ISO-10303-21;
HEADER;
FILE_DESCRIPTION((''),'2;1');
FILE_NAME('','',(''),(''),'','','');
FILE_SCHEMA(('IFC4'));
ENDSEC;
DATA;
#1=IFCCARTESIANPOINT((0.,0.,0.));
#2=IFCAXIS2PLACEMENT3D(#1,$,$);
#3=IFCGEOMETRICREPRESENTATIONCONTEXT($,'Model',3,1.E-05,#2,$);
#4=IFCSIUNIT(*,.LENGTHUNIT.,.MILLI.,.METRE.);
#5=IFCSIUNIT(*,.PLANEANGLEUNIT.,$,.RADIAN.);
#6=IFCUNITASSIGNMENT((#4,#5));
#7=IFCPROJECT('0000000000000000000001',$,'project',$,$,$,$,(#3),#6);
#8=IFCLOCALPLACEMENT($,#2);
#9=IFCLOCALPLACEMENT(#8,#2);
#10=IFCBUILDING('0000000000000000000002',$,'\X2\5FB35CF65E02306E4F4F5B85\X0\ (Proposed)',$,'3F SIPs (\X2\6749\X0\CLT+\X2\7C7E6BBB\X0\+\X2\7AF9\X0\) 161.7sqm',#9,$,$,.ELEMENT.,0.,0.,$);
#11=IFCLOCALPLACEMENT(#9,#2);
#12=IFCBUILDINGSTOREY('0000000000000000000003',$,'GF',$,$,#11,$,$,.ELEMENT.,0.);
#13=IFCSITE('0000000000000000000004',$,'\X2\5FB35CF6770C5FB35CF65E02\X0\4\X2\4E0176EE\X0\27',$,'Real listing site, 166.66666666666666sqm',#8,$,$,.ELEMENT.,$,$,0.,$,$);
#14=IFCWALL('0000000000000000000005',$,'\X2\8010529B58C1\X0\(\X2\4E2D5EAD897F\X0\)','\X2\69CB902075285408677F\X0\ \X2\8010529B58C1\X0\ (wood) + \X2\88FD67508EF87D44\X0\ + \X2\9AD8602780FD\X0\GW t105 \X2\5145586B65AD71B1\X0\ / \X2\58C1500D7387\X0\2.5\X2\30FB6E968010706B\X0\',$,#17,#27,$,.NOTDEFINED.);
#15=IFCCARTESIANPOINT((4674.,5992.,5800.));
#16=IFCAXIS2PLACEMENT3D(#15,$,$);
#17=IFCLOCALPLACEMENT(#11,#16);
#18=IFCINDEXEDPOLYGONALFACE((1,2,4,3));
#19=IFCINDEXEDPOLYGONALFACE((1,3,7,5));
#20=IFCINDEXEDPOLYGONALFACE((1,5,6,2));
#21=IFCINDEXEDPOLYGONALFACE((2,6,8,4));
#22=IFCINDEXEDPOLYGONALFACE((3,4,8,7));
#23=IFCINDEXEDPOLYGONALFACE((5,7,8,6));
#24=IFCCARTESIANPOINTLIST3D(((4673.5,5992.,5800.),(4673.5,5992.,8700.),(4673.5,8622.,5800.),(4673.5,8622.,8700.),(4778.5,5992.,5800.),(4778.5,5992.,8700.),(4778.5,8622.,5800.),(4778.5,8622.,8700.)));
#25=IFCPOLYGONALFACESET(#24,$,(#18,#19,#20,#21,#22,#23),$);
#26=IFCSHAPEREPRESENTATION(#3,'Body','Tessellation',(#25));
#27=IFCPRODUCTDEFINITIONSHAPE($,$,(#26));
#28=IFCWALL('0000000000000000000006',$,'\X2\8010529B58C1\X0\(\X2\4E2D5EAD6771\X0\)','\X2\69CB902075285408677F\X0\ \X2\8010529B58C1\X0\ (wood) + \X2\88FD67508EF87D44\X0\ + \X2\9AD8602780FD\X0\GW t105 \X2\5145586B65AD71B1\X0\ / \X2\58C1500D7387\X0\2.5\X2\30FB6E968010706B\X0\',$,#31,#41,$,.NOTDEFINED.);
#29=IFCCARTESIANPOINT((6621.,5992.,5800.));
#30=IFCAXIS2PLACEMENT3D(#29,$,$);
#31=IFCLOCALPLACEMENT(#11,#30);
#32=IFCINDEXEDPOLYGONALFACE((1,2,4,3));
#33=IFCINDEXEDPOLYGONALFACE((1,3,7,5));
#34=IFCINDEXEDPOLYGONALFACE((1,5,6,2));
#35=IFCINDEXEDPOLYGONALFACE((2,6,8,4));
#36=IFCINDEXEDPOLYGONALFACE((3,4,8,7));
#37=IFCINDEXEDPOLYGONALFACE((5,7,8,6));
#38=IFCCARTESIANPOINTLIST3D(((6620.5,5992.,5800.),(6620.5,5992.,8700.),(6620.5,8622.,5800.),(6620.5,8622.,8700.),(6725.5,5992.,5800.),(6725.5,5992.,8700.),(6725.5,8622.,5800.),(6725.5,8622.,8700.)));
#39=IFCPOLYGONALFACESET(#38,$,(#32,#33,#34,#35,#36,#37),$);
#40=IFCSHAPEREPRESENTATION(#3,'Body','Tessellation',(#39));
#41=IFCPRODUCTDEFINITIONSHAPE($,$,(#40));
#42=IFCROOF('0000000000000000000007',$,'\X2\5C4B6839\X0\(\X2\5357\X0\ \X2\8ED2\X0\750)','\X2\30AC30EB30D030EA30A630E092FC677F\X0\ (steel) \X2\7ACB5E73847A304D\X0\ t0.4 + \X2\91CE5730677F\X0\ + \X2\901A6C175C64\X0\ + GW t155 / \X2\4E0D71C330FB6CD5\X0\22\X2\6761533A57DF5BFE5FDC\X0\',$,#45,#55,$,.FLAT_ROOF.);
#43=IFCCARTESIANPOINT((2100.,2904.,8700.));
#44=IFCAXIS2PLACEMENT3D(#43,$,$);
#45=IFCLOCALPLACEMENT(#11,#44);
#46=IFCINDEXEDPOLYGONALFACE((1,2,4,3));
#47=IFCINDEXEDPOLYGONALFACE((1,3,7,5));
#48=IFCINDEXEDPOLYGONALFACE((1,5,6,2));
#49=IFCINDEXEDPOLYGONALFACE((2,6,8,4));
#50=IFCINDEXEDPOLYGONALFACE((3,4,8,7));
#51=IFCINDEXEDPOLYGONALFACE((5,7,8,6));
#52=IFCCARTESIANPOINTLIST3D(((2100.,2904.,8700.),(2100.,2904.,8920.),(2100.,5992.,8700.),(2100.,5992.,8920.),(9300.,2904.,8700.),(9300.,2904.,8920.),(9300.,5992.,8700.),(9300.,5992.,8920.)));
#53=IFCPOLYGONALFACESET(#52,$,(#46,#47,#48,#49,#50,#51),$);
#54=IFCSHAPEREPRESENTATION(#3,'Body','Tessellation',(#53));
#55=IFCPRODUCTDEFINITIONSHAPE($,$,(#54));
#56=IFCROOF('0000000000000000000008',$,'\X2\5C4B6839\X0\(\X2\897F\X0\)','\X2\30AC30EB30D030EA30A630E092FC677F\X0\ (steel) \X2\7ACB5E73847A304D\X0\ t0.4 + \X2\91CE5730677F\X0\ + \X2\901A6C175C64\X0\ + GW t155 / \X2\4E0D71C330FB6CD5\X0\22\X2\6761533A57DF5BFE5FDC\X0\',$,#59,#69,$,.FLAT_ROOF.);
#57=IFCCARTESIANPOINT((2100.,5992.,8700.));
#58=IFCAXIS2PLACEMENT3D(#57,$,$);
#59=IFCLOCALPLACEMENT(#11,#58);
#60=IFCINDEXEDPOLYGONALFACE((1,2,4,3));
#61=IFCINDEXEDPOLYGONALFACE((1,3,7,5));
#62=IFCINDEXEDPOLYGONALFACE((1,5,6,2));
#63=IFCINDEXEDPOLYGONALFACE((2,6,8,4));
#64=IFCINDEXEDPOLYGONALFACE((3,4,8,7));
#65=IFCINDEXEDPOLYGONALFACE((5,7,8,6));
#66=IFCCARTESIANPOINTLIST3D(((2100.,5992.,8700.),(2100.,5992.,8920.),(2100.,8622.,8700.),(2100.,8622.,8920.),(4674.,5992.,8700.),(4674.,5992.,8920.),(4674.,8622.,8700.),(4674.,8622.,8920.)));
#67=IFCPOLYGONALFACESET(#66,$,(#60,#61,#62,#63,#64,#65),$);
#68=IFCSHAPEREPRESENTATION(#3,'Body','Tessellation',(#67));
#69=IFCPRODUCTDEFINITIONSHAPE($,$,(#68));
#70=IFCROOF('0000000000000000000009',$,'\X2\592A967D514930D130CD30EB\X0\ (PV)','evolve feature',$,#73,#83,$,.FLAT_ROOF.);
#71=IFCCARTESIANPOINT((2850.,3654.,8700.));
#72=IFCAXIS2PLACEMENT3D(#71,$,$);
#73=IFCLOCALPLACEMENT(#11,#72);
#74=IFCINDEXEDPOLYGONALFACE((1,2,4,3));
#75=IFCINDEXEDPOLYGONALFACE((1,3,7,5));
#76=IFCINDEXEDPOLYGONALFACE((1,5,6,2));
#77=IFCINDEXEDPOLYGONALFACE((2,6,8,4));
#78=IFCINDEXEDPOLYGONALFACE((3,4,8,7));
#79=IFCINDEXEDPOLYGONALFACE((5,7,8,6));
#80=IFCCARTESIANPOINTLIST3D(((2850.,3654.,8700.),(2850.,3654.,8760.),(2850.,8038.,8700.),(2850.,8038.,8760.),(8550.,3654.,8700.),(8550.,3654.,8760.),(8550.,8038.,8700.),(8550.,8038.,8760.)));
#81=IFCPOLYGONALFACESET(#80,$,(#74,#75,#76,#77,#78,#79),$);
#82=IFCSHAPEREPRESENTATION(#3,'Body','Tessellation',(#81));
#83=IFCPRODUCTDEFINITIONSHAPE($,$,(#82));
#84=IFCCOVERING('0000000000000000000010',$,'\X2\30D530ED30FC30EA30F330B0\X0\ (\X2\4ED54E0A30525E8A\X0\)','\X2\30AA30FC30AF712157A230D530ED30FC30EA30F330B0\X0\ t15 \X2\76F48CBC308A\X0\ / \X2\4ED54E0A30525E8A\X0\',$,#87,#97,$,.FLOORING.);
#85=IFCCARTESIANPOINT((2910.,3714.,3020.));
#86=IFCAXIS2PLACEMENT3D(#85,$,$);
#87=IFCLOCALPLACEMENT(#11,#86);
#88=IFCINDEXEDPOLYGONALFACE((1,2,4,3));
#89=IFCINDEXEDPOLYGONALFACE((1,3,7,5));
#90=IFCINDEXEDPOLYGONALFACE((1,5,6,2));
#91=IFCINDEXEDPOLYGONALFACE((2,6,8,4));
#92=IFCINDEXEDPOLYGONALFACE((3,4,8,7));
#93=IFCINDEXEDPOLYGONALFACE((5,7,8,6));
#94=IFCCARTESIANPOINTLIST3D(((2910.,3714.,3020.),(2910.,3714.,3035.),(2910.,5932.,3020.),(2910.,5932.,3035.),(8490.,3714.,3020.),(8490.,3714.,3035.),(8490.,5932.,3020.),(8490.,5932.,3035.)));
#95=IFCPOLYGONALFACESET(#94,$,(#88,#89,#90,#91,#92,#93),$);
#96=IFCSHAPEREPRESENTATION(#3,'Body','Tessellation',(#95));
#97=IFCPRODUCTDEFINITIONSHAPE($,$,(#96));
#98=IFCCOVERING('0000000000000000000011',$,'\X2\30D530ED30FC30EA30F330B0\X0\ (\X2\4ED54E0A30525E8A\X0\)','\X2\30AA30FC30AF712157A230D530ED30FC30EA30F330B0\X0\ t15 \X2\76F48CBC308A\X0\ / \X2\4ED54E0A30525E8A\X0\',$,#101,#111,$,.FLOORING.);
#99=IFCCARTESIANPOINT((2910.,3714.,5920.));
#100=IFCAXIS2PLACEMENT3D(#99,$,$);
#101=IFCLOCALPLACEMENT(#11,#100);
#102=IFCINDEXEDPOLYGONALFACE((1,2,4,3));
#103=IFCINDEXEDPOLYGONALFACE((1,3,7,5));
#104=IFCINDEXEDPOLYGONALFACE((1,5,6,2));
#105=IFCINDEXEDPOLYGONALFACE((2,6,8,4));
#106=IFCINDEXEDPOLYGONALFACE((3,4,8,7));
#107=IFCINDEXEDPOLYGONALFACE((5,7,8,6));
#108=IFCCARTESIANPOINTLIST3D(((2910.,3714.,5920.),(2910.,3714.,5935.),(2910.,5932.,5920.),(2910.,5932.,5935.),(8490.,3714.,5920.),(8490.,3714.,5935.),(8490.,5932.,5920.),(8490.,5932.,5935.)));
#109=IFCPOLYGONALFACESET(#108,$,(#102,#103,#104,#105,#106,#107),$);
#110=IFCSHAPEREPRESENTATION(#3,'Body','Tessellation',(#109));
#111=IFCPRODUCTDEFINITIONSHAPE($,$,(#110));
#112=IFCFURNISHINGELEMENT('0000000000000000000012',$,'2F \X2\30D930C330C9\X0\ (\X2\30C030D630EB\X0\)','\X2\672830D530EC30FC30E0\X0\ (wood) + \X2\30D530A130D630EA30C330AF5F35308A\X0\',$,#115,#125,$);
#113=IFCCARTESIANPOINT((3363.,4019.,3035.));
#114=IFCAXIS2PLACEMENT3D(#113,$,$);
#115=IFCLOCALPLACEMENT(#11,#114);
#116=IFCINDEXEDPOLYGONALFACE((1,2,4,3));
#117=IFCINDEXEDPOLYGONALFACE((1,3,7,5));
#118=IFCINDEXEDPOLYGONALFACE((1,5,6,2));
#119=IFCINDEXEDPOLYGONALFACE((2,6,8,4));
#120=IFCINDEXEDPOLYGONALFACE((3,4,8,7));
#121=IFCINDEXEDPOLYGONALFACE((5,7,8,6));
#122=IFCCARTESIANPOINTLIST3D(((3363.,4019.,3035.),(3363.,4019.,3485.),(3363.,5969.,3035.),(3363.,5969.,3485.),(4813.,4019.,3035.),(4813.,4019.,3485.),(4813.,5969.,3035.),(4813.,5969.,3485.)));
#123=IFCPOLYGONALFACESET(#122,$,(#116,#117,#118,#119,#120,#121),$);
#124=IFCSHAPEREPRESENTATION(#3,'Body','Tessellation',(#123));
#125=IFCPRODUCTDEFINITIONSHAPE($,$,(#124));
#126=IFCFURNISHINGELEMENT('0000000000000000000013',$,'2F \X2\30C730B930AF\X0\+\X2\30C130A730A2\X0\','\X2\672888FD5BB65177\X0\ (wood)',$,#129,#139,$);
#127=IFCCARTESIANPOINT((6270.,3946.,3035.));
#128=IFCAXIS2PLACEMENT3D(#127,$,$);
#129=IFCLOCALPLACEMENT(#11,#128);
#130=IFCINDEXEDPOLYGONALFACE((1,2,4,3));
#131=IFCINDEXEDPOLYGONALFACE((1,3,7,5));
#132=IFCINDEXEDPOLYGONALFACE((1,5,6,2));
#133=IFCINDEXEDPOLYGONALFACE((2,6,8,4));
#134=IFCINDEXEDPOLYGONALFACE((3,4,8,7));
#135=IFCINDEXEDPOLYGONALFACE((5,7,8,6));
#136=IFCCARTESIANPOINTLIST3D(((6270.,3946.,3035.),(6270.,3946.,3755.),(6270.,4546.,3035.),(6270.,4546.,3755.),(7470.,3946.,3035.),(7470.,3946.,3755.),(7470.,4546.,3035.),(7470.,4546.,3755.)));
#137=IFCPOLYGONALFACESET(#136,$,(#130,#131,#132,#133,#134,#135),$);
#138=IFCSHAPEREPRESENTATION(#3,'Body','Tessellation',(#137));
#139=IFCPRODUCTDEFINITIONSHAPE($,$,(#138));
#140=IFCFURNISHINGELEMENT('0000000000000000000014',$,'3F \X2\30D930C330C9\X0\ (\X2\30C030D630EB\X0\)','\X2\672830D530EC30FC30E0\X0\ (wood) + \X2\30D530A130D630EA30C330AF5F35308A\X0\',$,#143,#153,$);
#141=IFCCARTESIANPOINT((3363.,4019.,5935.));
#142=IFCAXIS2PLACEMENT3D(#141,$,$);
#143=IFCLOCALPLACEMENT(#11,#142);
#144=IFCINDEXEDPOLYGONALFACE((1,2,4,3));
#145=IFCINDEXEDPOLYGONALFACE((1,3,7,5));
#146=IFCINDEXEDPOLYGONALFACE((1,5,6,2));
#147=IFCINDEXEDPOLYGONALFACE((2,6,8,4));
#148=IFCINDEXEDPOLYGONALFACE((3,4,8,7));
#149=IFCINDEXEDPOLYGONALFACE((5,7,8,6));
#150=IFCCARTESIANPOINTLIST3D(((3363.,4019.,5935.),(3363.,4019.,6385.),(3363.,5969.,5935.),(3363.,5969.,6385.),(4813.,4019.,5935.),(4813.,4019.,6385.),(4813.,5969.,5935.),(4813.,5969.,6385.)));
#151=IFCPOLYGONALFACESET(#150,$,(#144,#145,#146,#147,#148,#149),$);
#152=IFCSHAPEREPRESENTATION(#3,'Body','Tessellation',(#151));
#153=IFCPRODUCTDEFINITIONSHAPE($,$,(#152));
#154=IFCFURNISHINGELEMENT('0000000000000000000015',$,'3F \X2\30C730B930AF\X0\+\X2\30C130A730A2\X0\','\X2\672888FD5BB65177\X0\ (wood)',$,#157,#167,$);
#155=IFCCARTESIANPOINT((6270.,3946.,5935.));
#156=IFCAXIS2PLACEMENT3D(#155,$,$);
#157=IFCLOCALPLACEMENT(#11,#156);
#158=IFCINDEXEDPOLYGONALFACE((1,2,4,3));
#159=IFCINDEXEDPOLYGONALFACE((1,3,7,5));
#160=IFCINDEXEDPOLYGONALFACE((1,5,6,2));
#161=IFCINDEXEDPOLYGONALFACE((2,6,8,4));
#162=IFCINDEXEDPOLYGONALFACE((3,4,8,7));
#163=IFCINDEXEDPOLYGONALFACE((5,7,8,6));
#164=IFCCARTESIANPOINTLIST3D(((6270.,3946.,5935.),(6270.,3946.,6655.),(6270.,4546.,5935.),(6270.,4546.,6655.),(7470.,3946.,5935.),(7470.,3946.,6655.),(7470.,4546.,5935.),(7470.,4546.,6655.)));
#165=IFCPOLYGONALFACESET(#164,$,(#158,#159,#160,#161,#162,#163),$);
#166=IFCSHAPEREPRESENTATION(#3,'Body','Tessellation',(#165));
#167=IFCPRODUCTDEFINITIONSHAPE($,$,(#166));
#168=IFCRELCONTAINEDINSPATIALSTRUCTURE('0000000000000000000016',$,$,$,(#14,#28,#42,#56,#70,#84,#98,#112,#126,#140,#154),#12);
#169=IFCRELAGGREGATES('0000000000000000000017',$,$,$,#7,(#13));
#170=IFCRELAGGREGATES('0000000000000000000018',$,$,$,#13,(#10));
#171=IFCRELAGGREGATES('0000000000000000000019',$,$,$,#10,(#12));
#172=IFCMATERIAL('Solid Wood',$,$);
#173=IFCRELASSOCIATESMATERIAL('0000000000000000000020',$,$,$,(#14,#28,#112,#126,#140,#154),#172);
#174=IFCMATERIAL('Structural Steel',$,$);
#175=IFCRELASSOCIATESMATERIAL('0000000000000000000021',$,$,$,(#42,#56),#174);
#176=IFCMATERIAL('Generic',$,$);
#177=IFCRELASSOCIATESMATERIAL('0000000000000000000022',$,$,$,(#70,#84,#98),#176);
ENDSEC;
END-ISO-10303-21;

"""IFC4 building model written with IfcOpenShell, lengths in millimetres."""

from ifc_helpers import new_model, si_unit, frame, frame_2d, origin, place, context, project, spatial, rectangle, extrude, material, element, save


model = new_model("IFC4")

# Units and contexts
model_context = context("Model", 3, precision=1e-05, world=origin())
ifc_project = project(units=[si_unit("LENGTHUNIT", "METRE", prefix="MILLI"), si_unit("PLANEANGLEUNIT", "RADIAN")], contexts=[model_context])

# Site, building, storey
site_placement = place(None, origin())
site = spatial("IfcSite", under=ifc_project, at=site_placement, Name="徳島県徳島市4丁目27", ObjectType="Real listing site, 166.66666666666666sqm", CompositionType="ELEMENT", RefElevation=0.0)
building_placement = place(site_placement, origin())
building = spatial("IfcBuilding", under=site, at=building_placement, Name="徳島市の住宅 (Proposed)", ObjectType="3F SIPs (杉CLT+籾殻+竹) 161.7sqm", CompositionType="ELEMENT", ElevationOfRefHeight=0.0, ElevationOfTerrain=0.0)
storey_placement = place(building_placement, origin())
storey = spatial("IfcBuildingStorey", under=building, at=storey_placement, Name="GF", CompositionType="ELEMENT", Elevation=0.0)

# Shared definitions
ifc_material_1 = material(Name="Solid Wood")

# Walls
wall_1_placement = place(storey_placement, frame((4674.0, 5992.0, 5800.0)))
element("IfcWall", 1, at=wall_1_placement, inside=storey, material=ifc_material_1, Name="耐力壁(中庭西)", Description="構造用合板 耐力壁 (wood) + 製材軸組 + 高性能GW t105 充填断熱 / 壁倍率2.5・準耐火", PredefinedType="NOTDEFINED", context=model_context, shape_type="SweptSolid", body=[
    extrude(rectangle(XDim=105.0, YDim=2630.0, at=frame_2d((52.0, 1315.0))), frame((4674.0, 5992.0, 5800.0)), (0.0, 0.0, 1.0), 2900.0),
])
wall_2_placement = place(storey_placement, frame((6621.0, 5992.0, 5800.0)))
element("IfcWall", 2, at=wall_2_placement, inside=storey, material=ifc_material_1, Name="耐力壁(中庭東)", Description="構造用合板 耐力壁 (wood) + 製材軸組 + 高性能GW t105 充填断熱 / 壁倍率2.5・準耐火", PredefinedType="NOTDEFINED", context=model_context, shape_type="SweptSolid", body=[
    extrude(rectangle(XDim=105.0, YDim=2630.0, at=frame_2d((52.0, 1315.0))), frame((6621.0, 5992.0, 5800.0)), (0.0, 0.0, 1.0), 2900.0),
])

# Roofs
ifc_material_2 = material(Name="Structural Steel")
roof_1_placement = place(storey_placement, frame((2100.0, 2904.0, 8700.0)))
element("IfcRoof", 3, at=roof_1_placement, inside=storey, material=ifc_material_2, Name="屋根(南 軒750)", Description="ガルバリウム鋼板 (steel) 立平葺き t0.4 + 野地板 + 通気層 + GW t155 / 不燃・法22条区域対応", PredefinedType="FLAT_ROOF", context=model_context, shape_type="SweptSolid", body=[
    extrude(rectangle(XDim=7200.0, YDim=3088.0, at=frame_2d((3600.0, 1544.0))), frame((2100.0, 2904.0, 8700.0)), (0.0, 0.0, 1.0), 220.0),
])
roof_2_placement = place(storey_placement, frame((2100.0, 5992.0, 8700.0)))
element("IfcRoof", 4, at=roof_2_placement, inside=storey, material=ifc_material_2, Name="屋根(西)", Description="ガルバリウム鋼板 (steel) 立平葺き t0.4 + 野地板 + 通気層 + GW t155 / 不燃・法22条区域対応", PredefinedType="FLAT_ROOF", context=model_context, shape_type="SweptSolid", body=[
    extrude(rectangle(XDim=2574.0, YDim=2630.0, at=frame_2d((1287.0, 1315.0))), frame((2100.0, 5992.0, 8700.0)), (0.0, 0.0, 1.0), 220.0),
])
ifc_material_3 = material(Name="Generic")
roof_3_placement = place(storey_placement, frame((2850.0, 3654.0, 8700.0)))
element("IfcRoof", 5, at=roof_3_placement, inside=storey, material=ifc_material_3, Name="太陽光パネル (PV)", Description="evolve feature", PredefinedType="FLAT_ROOF", context=model_context, shape_type="SweptSolid", body=[
    extrude(rectangle(XDim=5700.0, YDim=4384.0, at=frame_2d((2850.0, 2192.0))), frame((2850.0, 3654.0, 8700.0)), (0.0, 0.0, 1.0), 60.0),
])

# Coverings
covering_1_placement = place(storey_placement, frame((2910.0, 3714.0, 3020.0)))
element("IfcCovering", 6, at=covering_1_placement, inside=storey, material=ifc_material_3, Name="フローリング (仕上げ床)", Description="オーク無垢フローリング t15 直貼り / 仕上げ床", PredefinedType="FLOORING", context=model_context, shape_type="SweptSolid", body=[
    extrude(rectangle(XDim=5580.0, YDim=2218.0, at=frame_2d((2790.0, 1109.0))), frame((2910.0, 3714.0, 3020.0)), (0.0, 0.0, 1.0), 15.0),
])
covering_2_placement = place(storey_placement, frame((2910.0, 3714.0, 5920.0)))
element("IfcCovering", 7, at=covering_2_placement, inside=storey, material=ifc_material_3, Name="フローリング (仕上げ床)", Description="オーク無垢フローリング t15 直貼り / 仕上げ床", PredefinedType="FLOORING", context=model_context, shape_type="SweptSolid", body=[
    extrude(rectangle(XDim=5580.0, YDim=2218.0, at=frame_2d((2790.0, 1109.0))), frame((2910.0, 3714.0, 5920.0)), (0.0, 0.0, 1.0), 15.0),
])

# Furnishing elements
furnishing_1_placement = place(storey_placement, frame((3363.0, 4019.0, 3035.0)))
element("IfcFurnishingElement", 8, at=furnishing_1_placement, inside=storey, material=ifc_material_1, Name="2F ベッド (ダブル)", Description="木フレーム (wood) + ファブリック張り", context=model_context, shape_type="SweptSolid", body=[
    extrude(rectangle(XDim=1450.0, YDim=1950.0, at=frame_2d((725.0, 975.0))), frame((3363.0, 4019.0, 3035.0)), (0.0, 0.0, 1.0), 450.0),
])
furnishing_2_placement = place(storey_placement, frame((6270.0, 3946.0, 3035.0)))
element("IfcFurnishingElement", 9, at=furnishing_2_placement, inside=storey, material=ifc_material_1, Name="2F デスク+チェア", Description="木製家具 (wood)", context=model_context, shape_type="SweptSolid", body=[
    extrude(rectangle(XDim=1200.0, YDim=600.0, at=frame_2d((600.0, 300.0))), frame((6270.0, 3946.0, 3035.0)), (0.0, 0.0, 1.0), 720.0),
])
furnishing_3_placement = place(storey_placement, frame((3363.0, 4019.0, 5935.0)))
element("IfcFurnishingElement", 10, at=furnishing_3_placement, inside=storey, material=ifc_material_1, Name="3F ベッド (ダブル)", Description="木フレーム (wood) + ファブリック張り", context=model_context, shape_type="SweptSolid", body=[
    extrude(rectangle(XDim=1450.0, YDim=1950.0, at=frame_2d((725.0, 975.0))), frame((3363.0, 4019.0, 5935.0)), (0.0, 0.0, 1.0), 450.0),
])
furnishing_4_placement = place(storey_placement, frame((6270.0, 3946.0, 5935.0)))
element("IfcFurnishingElement", 11, at=furnishing_4_placement, inside=storey, material=ifc_material_1, Name="3F デスク+チェア", Description="木製家具 (wood)", context=model_context, shape_type="SweptSolid", body=[
    extrude(rectangle(XDim=1200.0, YDim=600.0, at=frame_2d((600.0, 300.0))), frame((6270.0, 3946.0, 5935.0)), (0.0, 0.0, 1.0), 720.0),
])

save(model, "model.ifc")
